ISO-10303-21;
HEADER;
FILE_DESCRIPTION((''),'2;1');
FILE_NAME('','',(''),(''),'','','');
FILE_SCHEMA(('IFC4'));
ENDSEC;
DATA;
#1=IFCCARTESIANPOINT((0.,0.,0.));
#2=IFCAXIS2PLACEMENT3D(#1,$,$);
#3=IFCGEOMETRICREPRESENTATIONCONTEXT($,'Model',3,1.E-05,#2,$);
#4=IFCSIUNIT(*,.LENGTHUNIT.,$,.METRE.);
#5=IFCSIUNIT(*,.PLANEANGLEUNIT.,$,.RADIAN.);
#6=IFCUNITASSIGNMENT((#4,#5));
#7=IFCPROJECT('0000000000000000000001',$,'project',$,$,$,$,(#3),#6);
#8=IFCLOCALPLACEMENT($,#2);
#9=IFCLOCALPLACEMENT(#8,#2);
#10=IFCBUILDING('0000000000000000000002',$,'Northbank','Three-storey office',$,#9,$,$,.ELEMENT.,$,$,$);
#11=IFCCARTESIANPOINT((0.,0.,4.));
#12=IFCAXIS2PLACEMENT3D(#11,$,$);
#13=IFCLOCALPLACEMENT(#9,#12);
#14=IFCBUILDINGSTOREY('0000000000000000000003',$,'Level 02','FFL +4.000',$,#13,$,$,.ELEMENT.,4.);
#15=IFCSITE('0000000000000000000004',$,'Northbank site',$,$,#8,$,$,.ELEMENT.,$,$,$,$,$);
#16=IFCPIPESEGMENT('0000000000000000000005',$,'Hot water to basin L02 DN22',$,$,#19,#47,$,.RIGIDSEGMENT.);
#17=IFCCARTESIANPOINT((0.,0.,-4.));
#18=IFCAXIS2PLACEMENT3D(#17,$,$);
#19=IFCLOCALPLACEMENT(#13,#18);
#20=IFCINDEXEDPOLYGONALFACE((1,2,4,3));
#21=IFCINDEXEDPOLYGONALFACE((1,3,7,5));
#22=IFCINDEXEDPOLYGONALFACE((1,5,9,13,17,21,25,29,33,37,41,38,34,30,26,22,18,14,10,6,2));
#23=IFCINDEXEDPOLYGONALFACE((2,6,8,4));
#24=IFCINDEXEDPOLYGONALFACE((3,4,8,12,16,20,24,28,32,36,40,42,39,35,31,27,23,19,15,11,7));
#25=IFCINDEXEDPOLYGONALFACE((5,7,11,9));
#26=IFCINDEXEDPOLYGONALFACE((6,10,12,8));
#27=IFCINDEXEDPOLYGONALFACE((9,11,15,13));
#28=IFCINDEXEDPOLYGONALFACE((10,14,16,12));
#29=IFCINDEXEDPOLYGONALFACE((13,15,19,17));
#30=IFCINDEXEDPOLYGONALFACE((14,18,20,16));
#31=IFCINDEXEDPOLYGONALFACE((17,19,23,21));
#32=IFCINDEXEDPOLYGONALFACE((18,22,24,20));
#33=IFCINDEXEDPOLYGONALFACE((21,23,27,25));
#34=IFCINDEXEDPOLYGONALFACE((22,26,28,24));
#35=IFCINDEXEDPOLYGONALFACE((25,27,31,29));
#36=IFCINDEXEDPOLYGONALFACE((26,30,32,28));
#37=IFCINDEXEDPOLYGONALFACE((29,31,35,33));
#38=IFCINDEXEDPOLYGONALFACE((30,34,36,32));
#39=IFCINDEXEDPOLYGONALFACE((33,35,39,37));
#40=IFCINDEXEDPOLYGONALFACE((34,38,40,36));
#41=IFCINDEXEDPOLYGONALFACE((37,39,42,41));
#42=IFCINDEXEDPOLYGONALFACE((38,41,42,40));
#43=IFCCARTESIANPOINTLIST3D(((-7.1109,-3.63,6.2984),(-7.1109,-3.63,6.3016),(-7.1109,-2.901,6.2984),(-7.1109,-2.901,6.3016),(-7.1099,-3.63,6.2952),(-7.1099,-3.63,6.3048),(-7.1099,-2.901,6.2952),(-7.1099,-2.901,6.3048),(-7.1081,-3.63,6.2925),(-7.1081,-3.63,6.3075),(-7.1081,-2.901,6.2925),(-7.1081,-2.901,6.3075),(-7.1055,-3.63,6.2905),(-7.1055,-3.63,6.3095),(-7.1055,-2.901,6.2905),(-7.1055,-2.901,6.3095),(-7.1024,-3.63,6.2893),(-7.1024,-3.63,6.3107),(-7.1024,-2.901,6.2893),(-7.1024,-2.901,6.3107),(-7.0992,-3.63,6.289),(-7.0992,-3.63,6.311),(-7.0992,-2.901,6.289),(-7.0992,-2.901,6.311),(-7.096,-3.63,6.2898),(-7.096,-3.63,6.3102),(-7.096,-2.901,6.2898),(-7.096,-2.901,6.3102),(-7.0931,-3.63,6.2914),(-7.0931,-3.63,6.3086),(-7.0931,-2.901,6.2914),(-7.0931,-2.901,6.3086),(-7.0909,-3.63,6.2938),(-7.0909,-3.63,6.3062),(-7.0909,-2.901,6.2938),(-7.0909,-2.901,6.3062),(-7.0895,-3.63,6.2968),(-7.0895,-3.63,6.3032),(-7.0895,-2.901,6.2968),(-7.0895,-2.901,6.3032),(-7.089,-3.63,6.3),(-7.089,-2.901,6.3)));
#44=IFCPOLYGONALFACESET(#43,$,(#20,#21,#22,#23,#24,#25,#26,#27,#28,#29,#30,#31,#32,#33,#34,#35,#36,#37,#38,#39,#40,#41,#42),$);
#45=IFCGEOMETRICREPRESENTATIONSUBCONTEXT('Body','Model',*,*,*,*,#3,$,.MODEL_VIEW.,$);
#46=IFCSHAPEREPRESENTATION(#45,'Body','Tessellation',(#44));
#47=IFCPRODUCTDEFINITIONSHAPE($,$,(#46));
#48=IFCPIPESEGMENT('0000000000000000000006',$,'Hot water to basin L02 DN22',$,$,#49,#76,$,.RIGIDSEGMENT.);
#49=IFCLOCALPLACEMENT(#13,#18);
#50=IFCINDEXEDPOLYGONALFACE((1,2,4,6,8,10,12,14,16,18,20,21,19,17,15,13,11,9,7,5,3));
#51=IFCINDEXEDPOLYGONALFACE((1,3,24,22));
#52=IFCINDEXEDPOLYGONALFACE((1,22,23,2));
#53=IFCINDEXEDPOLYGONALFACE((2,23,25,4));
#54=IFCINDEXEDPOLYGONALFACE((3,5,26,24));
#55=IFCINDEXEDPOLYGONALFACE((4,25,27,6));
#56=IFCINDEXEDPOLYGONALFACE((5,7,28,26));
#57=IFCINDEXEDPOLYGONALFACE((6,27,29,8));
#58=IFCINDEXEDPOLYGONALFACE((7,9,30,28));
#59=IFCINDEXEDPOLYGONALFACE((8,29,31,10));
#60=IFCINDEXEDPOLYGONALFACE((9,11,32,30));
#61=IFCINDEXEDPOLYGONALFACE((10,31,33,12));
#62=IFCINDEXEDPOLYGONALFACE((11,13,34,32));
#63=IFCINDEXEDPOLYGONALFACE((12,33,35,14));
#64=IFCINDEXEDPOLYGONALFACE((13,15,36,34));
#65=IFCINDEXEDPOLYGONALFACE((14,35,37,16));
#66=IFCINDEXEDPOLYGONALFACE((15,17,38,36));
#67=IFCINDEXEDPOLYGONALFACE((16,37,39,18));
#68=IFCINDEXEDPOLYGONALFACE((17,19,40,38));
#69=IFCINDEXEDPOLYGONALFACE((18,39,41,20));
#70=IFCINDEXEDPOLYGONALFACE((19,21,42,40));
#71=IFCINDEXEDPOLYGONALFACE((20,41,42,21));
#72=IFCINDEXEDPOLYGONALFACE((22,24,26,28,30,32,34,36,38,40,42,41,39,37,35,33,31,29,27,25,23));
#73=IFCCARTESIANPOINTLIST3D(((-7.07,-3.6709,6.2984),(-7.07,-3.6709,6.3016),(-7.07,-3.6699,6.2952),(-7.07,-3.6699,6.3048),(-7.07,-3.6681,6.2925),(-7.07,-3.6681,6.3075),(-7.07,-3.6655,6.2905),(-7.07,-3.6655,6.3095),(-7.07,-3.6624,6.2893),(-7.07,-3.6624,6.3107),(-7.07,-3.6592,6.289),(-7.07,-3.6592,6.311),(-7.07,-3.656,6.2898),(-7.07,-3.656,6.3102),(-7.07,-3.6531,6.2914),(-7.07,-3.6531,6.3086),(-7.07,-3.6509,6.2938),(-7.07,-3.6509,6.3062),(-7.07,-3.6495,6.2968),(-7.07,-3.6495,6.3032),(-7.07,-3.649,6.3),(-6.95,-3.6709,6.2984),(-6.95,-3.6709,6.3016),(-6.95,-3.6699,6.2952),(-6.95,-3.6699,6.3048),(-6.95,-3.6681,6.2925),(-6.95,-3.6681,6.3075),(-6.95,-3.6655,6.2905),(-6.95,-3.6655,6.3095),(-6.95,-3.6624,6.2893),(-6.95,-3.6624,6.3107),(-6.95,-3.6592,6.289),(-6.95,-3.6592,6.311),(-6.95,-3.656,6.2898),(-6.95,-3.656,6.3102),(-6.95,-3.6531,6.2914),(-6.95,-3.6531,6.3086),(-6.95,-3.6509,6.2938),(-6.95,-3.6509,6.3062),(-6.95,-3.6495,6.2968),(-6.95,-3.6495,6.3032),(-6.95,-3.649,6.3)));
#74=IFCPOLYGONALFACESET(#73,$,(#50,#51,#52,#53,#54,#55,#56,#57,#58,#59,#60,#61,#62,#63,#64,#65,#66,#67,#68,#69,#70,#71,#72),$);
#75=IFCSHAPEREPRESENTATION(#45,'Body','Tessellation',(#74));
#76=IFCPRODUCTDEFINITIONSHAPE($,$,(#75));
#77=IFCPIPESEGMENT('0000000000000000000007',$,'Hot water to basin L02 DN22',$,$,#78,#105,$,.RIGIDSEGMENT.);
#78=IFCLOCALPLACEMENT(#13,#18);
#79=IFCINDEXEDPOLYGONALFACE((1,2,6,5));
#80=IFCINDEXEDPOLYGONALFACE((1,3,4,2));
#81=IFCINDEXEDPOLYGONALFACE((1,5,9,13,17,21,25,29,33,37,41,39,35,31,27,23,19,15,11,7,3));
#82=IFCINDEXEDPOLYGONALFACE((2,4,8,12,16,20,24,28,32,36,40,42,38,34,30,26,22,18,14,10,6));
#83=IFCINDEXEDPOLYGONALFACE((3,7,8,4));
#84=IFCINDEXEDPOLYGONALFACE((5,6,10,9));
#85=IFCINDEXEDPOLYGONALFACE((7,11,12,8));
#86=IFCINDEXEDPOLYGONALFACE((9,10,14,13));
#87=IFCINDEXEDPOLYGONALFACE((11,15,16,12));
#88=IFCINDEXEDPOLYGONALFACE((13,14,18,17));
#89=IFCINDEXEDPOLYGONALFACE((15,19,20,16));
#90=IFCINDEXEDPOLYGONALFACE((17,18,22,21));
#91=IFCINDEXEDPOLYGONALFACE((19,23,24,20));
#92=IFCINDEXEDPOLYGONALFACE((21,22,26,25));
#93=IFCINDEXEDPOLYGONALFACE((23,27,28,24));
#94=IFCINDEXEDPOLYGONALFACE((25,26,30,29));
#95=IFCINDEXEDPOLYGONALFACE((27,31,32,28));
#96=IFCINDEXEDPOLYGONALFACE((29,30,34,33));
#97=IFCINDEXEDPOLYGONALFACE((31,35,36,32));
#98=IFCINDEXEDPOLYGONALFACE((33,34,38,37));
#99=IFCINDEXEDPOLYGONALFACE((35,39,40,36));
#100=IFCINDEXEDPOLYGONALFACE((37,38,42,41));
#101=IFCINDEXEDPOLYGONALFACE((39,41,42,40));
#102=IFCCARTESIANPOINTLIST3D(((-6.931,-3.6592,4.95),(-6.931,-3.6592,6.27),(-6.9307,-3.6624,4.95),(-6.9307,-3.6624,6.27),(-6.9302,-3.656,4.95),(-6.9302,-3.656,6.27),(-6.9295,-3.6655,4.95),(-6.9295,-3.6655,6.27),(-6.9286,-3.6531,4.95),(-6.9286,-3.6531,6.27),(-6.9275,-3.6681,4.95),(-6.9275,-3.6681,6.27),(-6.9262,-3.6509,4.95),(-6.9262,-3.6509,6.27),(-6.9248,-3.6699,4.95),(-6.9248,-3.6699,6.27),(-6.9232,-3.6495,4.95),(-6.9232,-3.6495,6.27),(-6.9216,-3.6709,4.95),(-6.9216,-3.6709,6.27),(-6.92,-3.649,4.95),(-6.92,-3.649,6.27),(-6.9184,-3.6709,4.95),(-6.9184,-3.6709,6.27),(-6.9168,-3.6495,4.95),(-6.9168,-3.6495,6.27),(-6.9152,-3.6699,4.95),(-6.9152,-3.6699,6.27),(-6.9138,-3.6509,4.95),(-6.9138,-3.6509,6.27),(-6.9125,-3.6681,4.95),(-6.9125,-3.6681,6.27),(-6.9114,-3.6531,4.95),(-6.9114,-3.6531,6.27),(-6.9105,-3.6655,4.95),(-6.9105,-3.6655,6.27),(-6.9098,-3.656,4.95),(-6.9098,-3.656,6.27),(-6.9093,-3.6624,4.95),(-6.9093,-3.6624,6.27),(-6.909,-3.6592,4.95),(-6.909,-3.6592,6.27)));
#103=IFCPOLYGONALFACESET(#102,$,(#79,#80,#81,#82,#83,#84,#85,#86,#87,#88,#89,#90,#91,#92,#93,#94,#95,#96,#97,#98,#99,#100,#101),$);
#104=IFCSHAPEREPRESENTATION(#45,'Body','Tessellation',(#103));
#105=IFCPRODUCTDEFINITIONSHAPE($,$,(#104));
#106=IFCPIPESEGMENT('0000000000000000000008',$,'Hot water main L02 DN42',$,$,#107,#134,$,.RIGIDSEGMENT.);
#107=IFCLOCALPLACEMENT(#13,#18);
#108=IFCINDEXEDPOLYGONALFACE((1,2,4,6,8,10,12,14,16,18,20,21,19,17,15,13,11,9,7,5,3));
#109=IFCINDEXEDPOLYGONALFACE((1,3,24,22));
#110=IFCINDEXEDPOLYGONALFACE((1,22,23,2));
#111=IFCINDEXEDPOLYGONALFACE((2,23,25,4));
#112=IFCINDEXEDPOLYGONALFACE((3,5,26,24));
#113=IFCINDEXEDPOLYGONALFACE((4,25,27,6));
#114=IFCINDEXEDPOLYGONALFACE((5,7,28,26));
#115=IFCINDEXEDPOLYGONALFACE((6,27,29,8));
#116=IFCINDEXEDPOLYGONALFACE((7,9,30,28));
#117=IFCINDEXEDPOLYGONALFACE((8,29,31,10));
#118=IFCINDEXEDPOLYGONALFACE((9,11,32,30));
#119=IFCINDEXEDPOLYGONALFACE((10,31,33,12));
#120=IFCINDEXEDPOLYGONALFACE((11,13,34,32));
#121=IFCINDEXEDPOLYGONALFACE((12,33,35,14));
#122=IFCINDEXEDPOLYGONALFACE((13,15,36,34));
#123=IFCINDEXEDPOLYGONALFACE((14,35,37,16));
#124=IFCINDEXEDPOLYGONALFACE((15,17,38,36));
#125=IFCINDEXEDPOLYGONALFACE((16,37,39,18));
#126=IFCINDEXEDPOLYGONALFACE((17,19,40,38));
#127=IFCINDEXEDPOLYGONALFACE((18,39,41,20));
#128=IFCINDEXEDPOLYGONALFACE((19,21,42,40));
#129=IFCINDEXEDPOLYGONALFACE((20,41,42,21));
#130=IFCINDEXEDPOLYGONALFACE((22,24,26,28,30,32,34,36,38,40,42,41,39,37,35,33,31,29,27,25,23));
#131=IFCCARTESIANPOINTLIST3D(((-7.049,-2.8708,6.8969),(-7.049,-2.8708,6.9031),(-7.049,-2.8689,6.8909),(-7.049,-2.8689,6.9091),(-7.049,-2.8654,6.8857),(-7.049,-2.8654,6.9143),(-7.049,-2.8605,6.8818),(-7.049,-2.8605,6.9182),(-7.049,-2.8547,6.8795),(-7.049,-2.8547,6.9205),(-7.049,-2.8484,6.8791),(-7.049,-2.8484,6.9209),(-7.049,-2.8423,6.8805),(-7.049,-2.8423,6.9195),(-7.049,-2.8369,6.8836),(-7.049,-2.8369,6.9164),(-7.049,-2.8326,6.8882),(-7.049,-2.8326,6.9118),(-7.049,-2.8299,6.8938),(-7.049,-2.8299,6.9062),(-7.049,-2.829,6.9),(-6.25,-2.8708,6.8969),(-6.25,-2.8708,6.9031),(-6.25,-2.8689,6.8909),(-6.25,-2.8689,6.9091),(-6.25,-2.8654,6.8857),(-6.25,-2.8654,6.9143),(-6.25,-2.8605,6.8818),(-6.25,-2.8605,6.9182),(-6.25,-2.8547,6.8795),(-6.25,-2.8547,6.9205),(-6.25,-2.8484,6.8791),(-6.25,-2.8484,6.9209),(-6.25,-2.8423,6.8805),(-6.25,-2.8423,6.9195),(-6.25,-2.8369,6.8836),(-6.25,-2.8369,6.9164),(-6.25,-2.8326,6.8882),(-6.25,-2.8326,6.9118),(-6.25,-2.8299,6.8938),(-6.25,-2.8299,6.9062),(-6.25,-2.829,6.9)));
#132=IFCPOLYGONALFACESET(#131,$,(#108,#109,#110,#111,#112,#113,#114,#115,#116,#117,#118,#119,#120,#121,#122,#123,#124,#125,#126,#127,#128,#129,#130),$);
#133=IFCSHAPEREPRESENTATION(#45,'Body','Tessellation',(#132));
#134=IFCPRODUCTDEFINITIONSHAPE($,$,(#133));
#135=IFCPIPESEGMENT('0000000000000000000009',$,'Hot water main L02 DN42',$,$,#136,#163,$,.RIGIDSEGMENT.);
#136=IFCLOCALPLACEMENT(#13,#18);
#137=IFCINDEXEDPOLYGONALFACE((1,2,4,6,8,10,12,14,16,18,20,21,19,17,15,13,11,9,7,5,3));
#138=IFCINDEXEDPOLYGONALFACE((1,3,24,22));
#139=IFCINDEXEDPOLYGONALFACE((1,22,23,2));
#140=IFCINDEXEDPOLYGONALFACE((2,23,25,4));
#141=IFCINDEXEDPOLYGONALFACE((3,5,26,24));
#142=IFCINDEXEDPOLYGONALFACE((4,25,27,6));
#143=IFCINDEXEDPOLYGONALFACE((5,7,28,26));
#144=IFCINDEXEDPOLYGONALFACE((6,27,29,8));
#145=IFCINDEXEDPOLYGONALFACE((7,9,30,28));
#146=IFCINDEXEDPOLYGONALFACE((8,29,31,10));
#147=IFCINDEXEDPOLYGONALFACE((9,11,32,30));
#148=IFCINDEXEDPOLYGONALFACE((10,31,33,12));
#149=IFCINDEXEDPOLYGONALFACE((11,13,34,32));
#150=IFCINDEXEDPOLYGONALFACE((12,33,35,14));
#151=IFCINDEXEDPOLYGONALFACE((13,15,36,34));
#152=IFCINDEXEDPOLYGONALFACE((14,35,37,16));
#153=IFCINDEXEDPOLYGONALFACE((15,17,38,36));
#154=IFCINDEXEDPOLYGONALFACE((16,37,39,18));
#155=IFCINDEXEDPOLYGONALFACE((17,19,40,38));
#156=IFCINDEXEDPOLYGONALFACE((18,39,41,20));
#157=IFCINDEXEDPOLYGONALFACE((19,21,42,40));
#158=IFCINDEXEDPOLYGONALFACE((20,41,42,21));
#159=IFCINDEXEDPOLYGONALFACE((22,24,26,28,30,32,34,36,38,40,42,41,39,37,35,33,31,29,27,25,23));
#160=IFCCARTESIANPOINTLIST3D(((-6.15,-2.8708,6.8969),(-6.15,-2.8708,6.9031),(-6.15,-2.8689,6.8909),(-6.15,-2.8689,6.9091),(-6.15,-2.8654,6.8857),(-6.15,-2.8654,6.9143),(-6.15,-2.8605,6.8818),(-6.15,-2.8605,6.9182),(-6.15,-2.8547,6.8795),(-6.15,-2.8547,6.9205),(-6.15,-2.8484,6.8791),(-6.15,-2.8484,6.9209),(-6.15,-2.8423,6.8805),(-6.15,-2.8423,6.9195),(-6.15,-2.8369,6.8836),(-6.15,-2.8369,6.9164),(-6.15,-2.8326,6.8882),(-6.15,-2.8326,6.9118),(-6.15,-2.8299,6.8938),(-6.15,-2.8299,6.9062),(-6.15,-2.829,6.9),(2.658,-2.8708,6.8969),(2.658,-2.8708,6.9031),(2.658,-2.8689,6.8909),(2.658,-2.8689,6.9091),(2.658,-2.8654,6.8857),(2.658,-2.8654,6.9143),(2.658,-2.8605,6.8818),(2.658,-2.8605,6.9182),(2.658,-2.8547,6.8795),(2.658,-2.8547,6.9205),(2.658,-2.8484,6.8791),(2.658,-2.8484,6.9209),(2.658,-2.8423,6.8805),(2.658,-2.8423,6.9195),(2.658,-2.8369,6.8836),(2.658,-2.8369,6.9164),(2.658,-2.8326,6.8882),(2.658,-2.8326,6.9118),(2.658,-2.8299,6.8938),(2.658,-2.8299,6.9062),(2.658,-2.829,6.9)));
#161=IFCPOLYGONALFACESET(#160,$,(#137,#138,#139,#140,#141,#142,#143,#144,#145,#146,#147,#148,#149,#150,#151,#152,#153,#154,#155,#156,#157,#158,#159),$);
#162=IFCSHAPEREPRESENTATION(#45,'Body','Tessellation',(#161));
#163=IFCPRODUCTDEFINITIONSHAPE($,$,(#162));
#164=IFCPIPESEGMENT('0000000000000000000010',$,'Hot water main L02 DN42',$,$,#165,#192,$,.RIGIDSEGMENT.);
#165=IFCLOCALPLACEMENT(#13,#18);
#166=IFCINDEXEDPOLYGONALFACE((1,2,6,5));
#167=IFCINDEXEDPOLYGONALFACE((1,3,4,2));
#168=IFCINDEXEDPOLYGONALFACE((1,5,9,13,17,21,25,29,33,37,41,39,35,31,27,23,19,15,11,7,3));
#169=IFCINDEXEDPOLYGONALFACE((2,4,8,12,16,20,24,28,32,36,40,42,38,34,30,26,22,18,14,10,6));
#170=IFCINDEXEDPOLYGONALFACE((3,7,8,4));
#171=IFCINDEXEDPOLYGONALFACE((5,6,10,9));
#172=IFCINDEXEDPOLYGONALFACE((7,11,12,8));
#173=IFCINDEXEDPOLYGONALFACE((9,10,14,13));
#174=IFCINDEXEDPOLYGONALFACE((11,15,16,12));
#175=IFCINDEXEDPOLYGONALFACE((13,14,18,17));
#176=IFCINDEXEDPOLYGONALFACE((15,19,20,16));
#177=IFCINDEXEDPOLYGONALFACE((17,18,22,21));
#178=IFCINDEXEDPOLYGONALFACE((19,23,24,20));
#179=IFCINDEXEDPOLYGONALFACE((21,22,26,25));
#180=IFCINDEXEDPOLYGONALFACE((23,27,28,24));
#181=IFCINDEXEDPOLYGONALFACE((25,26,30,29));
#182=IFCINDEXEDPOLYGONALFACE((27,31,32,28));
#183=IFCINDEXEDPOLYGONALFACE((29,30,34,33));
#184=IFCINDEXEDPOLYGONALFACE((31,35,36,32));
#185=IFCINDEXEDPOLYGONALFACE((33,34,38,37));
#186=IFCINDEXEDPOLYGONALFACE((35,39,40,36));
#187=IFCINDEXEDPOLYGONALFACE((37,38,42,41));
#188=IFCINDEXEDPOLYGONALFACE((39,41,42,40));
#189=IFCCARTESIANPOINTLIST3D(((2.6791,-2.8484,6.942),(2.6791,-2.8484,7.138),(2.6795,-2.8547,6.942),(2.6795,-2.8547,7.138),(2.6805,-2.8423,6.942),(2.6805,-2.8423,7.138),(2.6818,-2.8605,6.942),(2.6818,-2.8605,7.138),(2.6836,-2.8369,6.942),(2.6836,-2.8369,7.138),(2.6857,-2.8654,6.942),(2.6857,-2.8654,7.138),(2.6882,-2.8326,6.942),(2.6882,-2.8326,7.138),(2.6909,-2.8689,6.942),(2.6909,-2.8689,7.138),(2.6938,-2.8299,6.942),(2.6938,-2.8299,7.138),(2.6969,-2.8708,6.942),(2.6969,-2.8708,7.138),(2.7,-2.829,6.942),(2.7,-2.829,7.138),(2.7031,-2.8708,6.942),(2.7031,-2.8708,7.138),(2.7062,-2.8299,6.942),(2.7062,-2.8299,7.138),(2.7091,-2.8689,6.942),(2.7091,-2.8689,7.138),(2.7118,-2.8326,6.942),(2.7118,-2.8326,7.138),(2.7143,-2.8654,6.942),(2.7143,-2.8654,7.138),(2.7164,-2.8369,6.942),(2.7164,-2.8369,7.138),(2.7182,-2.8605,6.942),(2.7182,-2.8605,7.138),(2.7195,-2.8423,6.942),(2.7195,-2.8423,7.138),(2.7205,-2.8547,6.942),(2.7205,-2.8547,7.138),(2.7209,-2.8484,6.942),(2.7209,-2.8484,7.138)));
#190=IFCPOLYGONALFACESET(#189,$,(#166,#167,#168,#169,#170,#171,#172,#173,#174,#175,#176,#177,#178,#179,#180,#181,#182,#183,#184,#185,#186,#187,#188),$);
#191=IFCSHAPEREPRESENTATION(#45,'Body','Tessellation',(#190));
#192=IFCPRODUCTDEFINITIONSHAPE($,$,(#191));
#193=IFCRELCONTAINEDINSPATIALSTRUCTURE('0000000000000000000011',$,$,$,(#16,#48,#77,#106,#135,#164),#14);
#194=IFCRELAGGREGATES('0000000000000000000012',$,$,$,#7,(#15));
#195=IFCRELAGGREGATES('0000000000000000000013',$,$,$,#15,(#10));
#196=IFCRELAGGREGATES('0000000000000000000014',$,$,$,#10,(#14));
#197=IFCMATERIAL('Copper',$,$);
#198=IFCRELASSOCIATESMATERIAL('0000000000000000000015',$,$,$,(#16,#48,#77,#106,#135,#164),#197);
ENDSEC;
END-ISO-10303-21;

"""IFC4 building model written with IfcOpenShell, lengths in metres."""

from ifc_helpers import new_model, si_unit, frame, origin, place, context, subcontext, project, spatial, circle, extrude, material, element, save


model = new_model("IFC4")

# Units and contexts
model_context = context("Model", 3, precision=1e-05, world=origin())
body_context = subcontext(model_context, "Body", "Model", "MODEL_VIEW")
ifc_project = project(units=[si_unit("LENGTHUNIT", "METRE"), si_unit("PLANEANGLEUNIT", "RADIAN")], contexts=[model_context])

# Site, building, storey
site_placement = place(None, origin())
site = spatial("IfcSite", under=ifc_project, at=site_placement, Name="Northbank site", CompositionType="ELEMENT")
building_placement = place(site_placement, origin())
building = spatial("IfcBuilding", under=site, at=building_placement, Name="Northbank", Description="Three-storey office", CompositionType="ELEMENT")
storey_placement = place(building_placement, frame((0.0, 0.0, 4.0)))
storey = spatial("IfcBuildingStorey", under=building, at=storey_placement, Name="Level 02", Description="FFL +4.000", CompositionType="ELEMENT", Elevation=4.0)

# Shared definitions
ifc_material = material(Name="Copper")

# Pipe segments
pipe_segment_1_placement = place(storey_placement, frame((0.0, 0.0, -4.0)))
element("IfcPipeSegment", 1, at=pipe_segment_1_placement, inside=storey, material=ifc_material, Name="Hot water to basin L02 DN22", PredefinedType="RIGIDSEGMENT", context=body_context, shape_type="SweptSolid", body=[
    extrude(circle(Radius=0.011), frame((-7.1, -2.901, 6.3), z_axis=(0.0, -1.0, 0.0), x_axis=(1.0, 0.0, 0.0)), (0.0, 0.0, 1.0), 0.729),
])
pipe_segment_2_placement = place(storey_placement, frame((0.0, 0.0, -4.0)))
element("IfcPipeSegment", 2, at=pipe_segment_2_placement, inside=storey, material=ifc_material, Name="Hot water to basin L02 DN22", PredefinedType="RIGIDSEGMENT", context=body_context, shape_type="SweptSolid", body=[
    extrude(circle(Radius=0.011), frame((-7.07, -3.66, 6.3), z_axis=(1.0, 0.0, 0.0), x_axis=(0.0, 1.0, 0.0)), (0.0, 0.0, 1.0), 0.12),
])
pipe_segment_3_placement = place(storey_placement, frame((0.0, 0.0, -4.0)))
element("IfcPipeSegment", 3, at=pipe_segment_3_placement, inside=storey, material=ifc_material, Name="Hot water to basin L02 DN22", PredefinedType="RIGIDSEGMENT", context=body_context, shape_type="SweptSolid", body=[
    extrude(circle(Radius=0.011), frame((-6.92, -3.66, 6.27), z_axis=(0.0, 0.0, -1.0), x_axis=(0.0, 1.0, 0.0)), (0.0, 0.0, 1.0), 1.32),
])
pipe_segment_4_placement = place(storey_placement, frame((0.0, 0.0, -4.0)))
element("IfcPipeSegment", 4, at=pipe_segment_4_placement, inside=storey, material=ifc_material, Name="Hot water main L02 DN42", PredefinedType="RIGIDSEGMENT", context=body_context, shape_type="SweptSolid", body=[
    extrude(circle(Radius=0.021), frame((-7.049, -2.85, 6.9), z_axis=(1.0, 0.0, 0.0), x_axis=(0.0, 1.0, 0.0)), (0.0, 0.0, 1.0), 0.799),
])

# Pipe segments
pipe_segment_5_placement = place(storey_placement, frame((0.0, 0.0, -4.0)))
element("IfcPipeSegment", 5, at=pipe_segment_5_placement, inside=storey, material=ifc_material, Name="Hot water main L02 DN42", PredefinedType="RIGIDSEGMENT", context=body_context, shape_type="SweptSolid", body=[
    extrude(circle(Radius=0.021), frame((-6.15, -2.85, 6.9), z_axis=(1.0, 0.0, 0.0), x_axis=(0.0, 1.0, 0.0)), (0.0, 0.0, 1.0), 8.808),
])
pipe_segment_6_placement = place(storey_placement, frame((0.0, 0.0, -4.0)))
element("IfcPipeSegment", 6, at=pipe_segment_6_placement, inside=storey, material=ifc_material, Name="Hot water main L02 DN42", PredefinedType="RIGIDSEGMENT", context=body_context, shape_type="SweptSolid", body=[
    extrude(circle(Radius=0.021), frame((2.7, -2.85, 6.942), z_axis=(0.0, 0.0, 1.0), x_axis=(0.0, 1.0, 0.0)), (0.0, 0.0, 1.0), 0.196),
])

save(model, "model.ifc")
